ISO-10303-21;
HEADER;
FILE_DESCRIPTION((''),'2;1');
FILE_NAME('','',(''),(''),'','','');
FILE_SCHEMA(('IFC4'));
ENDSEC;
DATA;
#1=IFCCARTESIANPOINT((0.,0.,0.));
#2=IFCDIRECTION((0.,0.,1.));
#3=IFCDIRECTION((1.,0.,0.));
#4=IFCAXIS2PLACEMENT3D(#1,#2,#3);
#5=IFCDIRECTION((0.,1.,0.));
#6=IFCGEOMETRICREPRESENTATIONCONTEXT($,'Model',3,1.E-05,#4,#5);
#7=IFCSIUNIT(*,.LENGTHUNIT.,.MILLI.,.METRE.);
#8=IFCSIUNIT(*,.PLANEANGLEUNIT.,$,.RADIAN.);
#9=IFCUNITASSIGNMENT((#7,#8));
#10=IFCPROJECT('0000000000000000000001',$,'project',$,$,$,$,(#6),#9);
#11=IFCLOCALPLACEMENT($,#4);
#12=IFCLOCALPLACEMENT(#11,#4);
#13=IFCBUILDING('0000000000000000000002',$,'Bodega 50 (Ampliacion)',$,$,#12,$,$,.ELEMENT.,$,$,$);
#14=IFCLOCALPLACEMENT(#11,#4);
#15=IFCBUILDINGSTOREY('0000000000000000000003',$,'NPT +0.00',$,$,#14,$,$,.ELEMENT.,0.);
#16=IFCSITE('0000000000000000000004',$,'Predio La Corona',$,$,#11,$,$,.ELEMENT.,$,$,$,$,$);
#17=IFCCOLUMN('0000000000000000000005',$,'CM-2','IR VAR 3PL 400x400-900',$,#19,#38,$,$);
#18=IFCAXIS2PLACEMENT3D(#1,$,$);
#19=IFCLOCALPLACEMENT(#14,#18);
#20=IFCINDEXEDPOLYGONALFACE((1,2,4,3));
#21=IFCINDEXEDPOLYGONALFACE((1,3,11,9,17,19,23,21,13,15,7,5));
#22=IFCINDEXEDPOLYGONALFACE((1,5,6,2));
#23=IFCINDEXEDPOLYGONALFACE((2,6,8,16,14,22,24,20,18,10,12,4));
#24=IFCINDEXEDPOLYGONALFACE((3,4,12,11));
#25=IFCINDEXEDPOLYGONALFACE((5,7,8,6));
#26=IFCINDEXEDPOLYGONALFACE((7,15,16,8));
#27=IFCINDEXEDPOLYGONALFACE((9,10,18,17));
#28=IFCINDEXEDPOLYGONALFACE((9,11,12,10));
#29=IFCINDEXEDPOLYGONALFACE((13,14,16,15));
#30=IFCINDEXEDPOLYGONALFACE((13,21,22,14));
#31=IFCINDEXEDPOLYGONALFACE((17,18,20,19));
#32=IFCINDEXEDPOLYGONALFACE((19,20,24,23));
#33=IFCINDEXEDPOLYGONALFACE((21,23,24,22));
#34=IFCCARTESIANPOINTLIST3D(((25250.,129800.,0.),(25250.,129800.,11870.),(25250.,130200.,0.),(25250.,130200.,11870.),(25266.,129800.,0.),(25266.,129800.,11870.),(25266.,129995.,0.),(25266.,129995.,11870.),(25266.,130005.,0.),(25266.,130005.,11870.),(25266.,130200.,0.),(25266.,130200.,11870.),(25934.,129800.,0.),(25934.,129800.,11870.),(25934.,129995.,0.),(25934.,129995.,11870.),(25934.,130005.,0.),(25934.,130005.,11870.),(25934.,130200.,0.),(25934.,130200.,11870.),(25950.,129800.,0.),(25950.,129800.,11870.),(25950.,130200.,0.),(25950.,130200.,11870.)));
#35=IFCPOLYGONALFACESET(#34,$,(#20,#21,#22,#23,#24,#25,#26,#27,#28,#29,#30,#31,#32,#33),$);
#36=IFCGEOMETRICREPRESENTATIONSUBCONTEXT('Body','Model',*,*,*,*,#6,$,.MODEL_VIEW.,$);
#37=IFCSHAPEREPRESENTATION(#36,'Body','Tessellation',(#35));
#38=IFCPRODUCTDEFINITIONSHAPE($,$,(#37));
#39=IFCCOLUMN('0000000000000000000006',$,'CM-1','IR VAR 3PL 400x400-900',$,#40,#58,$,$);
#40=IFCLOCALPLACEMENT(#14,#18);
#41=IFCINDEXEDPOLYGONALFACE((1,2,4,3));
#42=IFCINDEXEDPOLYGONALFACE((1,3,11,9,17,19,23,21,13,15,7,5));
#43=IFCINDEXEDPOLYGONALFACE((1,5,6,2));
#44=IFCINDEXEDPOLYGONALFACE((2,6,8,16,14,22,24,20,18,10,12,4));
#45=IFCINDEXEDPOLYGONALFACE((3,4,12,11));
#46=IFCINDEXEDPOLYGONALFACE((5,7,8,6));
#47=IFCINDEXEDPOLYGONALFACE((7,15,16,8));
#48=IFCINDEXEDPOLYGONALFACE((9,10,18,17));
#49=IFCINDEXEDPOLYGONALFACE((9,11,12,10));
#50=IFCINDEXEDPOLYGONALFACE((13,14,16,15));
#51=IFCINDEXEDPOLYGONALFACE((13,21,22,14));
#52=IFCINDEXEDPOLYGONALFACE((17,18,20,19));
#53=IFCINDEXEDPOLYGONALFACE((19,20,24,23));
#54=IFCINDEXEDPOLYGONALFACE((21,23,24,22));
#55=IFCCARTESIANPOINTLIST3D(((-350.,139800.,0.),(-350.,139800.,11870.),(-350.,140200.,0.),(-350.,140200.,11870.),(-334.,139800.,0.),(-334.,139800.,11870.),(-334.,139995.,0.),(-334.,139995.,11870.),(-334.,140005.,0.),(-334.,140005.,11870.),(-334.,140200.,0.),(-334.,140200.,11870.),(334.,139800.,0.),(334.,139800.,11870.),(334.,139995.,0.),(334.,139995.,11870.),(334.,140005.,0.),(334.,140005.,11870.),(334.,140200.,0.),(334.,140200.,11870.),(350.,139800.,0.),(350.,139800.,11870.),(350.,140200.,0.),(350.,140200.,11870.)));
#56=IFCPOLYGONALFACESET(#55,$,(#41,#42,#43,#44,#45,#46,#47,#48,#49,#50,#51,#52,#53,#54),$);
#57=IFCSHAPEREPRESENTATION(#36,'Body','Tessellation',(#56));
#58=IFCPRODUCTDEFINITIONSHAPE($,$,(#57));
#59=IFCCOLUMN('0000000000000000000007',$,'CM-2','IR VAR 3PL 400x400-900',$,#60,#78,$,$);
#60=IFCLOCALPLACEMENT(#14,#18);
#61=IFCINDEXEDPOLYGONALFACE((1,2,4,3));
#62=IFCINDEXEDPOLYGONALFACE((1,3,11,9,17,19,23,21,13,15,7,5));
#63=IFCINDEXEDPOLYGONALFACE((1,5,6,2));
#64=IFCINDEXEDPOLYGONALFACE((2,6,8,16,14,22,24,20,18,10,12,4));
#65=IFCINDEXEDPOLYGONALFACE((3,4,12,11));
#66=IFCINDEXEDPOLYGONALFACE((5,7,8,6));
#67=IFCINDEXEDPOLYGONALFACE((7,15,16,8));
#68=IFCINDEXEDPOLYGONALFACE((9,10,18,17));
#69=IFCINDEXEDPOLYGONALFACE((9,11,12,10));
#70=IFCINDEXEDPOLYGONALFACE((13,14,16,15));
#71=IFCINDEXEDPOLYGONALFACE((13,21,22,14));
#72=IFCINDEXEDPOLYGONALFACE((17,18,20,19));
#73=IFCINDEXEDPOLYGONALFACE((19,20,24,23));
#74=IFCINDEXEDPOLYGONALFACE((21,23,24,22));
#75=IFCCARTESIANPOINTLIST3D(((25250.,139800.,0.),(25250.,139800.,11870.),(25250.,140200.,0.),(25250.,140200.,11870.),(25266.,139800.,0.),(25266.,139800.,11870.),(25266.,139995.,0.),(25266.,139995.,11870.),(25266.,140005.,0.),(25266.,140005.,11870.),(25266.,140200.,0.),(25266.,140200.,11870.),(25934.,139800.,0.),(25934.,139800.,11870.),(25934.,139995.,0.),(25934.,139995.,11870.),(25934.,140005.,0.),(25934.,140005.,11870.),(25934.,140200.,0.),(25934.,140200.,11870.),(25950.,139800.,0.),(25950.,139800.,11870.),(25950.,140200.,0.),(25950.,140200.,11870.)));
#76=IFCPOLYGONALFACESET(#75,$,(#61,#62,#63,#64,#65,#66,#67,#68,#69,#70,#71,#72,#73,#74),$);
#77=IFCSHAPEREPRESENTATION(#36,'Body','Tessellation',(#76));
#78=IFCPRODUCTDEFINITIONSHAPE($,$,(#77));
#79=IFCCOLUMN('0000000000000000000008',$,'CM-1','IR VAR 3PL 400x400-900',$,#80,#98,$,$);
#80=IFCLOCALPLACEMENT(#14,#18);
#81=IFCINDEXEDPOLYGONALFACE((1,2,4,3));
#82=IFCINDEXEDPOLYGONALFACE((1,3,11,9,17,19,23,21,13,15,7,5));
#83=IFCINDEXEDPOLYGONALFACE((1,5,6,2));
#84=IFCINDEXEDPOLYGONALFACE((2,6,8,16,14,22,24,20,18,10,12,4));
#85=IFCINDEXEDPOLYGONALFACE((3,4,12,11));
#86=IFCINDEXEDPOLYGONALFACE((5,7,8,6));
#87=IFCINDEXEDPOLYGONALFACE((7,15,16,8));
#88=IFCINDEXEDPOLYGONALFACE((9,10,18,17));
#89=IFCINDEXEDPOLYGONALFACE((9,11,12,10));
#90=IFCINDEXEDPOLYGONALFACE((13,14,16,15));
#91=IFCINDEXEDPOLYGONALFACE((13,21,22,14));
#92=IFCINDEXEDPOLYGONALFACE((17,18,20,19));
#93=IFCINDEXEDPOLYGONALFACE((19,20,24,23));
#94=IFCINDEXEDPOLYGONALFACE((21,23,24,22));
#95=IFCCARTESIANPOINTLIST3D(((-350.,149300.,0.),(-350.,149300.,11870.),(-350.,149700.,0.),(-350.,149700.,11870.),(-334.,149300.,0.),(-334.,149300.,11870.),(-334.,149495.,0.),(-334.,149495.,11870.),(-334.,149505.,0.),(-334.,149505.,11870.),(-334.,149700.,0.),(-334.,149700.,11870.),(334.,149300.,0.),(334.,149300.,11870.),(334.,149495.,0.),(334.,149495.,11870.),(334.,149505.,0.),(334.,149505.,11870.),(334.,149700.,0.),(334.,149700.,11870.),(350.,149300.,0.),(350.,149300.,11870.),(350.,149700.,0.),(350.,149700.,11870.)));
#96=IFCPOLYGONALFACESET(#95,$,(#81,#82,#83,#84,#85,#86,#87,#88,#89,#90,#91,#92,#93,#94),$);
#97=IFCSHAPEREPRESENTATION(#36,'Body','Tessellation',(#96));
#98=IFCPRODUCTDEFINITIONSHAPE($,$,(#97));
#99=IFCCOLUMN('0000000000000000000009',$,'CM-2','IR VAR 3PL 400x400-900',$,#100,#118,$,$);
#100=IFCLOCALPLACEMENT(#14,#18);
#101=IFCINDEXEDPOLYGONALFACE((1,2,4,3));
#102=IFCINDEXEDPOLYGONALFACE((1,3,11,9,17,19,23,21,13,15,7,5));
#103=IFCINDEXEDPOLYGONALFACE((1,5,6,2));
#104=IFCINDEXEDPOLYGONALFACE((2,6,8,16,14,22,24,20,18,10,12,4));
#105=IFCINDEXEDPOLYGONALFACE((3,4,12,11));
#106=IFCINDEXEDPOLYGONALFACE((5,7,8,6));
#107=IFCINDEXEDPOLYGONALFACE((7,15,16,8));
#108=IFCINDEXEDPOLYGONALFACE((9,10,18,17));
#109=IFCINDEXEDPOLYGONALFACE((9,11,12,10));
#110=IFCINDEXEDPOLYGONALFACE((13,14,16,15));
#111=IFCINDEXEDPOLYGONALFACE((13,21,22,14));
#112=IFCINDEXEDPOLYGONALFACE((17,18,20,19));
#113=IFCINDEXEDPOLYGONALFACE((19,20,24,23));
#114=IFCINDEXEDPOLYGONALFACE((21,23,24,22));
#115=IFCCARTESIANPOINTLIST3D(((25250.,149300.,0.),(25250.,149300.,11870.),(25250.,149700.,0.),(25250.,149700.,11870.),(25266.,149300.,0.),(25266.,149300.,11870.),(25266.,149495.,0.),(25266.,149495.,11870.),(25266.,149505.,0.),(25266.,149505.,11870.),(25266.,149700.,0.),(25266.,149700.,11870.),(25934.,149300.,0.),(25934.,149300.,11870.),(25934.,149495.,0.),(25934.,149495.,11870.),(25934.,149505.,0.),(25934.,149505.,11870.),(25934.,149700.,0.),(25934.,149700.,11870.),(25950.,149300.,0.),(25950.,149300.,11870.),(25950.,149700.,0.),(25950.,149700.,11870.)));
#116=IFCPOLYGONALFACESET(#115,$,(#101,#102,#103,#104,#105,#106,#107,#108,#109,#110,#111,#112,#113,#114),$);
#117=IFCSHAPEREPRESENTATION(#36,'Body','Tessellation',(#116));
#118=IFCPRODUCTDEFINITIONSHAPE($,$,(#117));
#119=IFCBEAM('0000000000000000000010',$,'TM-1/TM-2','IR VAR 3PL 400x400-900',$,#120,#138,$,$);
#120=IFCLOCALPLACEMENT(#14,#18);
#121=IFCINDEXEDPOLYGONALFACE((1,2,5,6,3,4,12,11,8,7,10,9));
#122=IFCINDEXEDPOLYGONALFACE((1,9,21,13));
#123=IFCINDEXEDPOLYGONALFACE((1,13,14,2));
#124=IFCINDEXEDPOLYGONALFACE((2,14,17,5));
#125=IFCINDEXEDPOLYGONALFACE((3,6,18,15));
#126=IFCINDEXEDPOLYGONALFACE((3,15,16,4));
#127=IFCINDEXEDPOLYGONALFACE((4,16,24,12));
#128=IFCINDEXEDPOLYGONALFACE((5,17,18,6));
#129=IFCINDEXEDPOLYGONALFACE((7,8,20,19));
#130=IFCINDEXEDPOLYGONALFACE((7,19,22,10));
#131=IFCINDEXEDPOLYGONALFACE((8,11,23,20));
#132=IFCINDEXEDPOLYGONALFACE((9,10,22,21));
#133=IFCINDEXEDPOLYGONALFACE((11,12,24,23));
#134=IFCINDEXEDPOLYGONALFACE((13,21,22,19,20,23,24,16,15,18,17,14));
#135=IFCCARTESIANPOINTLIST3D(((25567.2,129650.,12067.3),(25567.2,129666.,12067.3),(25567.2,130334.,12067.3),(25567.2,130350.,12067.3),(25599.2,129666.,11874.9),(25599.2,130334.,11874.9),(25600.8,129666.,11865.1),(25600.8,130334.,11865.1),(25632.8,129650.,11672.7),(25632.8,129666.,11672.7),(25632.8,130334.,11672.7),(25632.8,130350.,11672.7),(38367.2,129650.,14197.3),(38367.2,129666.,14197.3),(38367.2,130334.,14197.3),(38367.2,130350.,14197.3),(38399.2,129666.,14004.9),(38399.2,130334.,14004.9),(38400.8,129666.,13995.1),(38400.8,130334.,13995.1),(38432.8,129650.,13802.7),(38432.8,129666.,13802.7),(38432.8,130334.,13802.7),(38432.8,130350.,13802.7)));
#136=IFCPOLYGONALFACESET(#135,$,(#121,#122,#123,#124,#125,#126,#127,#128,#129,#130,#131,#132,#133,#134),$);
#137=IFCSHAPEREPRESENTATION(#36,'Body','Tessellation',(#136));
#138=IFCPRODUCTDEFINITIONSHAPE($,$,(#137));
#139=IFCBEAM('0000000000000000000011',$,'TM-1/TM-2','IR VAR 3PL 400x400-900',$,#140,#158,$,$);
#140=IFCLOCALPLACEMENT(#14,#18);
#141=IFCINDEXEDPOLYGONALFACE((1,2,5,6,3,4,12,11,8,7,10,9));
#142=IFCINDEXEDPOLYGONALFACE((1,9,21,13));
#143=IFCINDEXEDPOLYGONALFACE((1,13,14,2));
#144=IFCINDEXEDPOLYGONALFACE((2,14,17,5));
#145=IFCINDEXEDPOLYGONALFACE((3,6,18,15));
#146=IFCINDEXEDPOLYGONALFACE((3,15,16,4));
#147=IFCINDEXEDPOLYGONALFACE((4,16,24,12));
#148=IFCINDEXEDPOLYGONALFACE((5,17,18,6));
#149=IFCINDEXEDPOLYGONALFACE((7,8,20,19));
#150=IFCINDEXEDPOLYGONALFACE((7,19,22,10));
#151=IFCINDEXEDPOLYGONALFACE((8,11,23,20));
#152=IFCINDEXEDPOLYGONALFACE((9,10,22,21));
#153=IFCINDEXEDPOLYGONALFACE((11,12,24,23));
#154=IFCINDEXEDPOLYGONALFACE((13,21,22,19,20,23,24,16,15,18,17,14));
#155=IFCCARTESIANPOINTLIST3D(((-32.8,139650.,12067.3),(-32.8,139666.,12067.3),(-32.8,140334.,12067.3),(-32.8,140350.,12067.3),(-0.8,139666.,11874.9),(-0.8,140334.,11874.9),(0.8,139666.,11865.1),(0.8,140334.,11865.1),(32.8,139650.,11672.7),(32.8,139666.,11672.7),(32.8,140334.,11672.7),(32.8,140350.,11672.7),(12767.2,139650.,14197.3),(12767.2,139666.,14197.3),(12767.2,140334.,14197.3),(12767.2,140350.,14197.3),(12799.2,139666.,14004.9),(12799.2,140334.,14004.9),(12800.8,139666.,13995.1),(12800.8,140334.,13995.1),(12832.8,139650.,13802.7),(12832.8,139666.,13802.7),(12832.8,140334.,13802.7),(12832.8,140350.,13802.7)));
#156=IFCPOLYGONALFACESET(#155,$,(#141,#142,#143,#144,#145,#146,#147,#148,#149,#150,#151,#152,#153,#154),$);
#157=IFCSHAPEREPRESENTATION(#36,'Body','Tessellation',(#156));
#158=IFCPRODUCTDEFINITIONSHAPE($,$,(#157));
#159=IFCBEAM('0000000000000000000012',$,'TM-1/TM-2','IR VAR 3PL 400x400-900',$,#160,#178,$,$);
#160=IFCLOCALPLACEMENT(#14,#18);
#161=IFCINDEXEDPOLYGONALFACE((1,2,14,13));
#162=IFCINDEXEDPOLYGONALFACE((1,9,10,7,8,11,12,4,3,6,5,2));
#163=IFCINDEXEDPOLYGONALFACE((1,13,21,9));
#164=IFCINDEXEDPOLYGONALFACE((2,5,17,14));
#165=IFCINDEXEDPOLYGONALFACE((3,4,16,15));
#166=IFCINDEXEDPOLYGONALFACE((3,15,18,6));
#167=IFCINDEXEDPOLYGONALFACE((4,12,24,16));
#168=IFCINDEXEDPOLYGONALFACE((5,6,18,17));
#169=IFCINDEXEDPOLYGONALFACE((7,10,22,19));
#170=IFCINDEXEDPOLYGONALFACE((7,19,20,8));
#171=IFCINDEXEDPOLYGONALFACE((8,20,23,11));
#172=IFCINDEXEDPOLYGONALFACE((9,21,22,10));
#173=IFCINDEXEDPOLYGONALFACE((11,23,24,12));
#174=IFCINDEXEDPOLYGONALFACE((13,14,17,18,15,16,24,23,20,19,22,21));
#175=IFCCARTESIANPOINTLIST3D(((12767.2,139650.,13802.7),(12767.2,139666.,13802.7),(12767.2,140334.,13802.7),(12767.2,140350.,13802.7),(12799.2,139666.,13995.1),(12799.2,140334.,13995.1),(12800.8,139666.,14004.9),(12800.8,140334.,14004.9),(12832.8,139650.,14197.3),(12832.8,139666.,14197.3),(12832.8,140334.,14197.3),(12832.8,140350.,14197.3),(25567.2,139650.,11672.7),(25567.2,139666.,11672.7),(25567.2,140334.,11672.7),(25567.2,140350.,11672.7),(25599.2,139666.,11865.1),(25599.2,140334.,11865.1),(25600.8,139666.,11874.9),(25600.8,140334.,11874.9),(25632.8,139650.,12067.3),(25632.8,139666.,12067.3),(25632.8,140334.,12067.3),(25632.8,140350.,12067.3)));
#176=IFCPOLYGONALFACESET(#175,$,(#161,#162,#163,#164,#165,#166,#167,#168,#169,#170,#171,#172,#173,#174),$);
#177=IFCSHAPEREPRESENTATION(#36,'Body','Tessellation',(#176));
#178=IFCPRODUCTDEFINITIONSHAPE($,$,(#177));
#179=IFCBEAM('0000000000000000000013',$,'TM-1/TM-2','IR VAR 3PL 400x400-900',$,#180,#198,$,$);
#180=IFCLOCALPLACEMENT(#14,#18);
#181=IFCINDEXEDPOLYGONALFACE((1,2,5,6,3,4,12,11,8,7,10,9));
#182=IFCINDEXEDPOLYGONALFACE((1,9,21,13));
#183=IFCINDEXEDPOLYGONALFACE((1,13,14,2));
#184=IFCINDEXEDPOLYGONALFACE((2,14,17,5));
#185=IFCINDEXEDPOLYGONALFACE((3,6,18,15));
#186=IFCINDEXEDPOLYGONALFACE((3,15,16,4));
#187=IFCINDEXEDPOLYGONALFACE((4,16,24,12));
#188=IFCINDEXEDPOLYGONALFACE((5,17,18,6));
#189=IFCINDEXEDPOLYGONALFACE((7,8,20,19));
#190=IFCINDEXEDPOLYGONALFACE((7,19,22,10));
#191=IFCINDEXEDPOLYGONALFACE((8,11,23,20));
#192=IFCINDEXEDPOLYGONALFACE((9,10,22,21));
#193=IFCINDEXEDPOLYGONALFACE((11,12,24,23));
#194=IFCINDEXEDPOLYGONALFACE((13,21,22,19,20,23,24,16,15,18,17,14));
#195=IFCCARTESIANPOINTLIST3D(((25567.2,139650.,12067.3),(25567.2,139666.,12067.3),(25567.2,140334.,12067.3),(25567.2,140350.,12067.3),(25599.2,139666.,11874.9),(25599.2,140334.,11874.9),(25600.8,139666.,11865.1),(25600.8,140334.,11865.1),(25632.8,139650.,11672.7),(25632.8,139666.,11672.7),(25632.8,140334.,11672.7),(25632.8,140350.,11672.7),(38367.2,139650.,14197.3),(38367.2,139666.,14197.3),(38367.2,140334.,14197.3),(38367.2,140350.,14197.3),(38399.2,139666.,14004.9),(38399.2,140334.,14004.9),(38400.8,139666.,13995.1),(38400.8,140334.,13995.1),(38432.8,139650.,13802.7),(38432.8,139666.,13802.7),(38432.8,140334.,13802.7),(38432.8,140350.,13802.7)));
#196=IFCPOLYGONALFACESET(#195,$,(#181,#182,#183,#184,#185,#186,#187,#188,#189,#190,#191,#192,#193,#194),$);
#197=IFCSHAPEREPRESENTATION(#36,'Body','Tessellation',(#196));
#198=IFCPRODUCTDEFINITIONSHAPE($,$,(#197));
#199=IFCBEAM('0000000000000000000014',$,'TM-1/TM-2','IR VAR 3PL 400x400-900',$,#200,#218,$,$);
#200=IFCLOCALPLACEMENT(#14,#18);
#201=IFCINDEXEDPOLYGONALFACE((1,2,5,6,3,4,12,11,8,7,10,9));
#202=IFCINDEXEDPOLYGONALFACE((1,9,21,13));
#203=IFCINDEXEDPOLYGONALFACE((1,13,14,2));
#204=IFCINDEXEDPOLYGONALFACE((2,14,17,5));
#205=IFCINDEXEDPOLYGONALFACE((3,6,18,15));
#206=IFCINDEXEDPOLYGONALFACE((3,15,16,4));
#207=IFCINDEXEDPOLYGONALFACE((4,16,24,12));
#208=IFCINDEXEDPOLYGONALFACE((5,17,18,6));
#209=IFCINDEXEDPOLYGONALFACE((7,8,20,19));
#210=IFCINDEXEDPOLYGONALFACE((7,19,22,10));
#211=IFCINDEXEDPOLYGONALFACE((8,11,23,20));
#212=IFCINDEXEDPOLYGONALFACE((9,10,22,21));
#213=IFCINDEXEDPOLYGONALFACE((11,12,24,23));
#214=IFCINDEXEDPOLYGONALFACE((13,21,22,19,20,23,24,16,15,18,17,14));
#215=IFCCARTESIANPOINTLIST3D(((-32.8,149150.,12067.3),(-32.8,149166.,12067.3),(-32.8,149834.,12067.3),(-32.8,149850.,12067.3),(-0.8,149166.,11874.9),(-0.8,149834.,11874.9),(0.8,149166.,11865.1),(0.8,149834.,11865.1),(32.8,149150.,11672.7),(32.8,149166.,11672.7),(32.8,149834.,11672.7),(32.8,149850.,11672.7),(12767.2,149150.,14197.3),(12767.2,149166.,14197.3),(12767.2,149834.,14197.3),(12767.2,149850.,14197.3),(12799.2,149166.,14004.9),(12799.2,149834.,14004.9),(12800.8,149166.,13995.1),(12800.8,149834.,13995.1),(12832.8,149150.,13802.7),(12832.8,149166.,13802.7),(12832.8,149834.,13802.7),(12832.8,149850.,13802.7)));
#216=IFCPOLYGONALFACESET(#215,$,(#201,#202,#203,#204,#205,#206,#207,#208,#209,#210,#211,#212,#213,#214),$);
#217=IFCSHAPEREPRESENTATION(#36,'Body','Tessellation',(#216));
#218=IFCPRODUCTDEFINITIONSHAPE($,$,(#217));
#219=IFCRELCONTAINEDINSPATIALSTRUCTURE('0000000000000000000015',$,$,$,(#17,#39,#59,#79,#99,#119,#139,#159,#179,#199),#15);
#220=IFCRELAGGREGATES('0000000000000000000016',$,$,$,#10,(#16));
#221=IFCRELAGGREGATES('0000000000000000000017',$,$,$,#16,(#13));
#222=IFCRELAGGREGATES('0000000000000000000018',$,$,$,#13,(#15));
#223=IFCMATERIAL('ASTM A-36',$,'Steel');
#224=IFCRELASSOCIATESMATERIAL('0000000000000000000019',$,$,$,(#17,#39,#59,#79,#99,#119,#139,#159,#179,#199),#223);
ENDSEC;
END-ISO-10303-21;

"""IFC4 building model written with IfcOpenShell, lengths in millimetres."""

from ifc_helpers import new_model, si_unit, direction, frame, origin_with_axes, origin_2d, place, context, subcontext, project, spatial, i_section, extrude, material, element, save


model = new_model("IFC4")

# Units and contexts
model_context = context("Model", 3, precision=1e-05, world=origin_with_axes(), true_north=direction((0.0, 1.0, 0.0)))
body_context = subcontext(model_context, "Body", "Model", "MODEL_VIEW")
ifc_project = project(units=[si_unit("LENGTHUNIT", "METRE", prefix="MILLI"), si_unit("PLANEANGLEUNIT", "RADIAN")], contexts=[model_context])

# Site, building, storey
site_placement = place(None, origin_with_axes())
site = spatial("IfcSite", under=ifc_project, at=site_placement, Name="Predio La Corona", CompositionType="ELEMENT")
building_placement = place(site_placement, origin_with_axes())
building = spatial("IfcBuilding", under=site, at=building_placement, Name="Bodega 50 (Ampliacion)", CompositionType="ELEMENT")
storey_placement = place(site_placement, origin_with_axes())
storey = spatial("IfcBuildingStorey", under=building, at=storey_placement, Name="NPT +0.00", CompositionType="ELEMENT", Elevation=0.0)

# Columns
ifc_material = material(Name="ASTM A-36", Category="Steel")
for number, where, z_axis, x_axis, name in (
    (1, (25600.0, 130000.0, 0.0), (0.0, 0.0, 1.0), (0.0, -1.0, 0.0), "CM-2"),
    (2, (0.0, 140000.0, 0.0), (0.0, 0.0, 1.0), (0.0, -1.0, 0.0), "CM-1"),
    (3, (25600.0, 140000.0, 0.0), (0.0, 0.0, 1.0), (0.0, -1.0, 0.0), "CM-2"),
    (4, (0.0, 149500.0, 0.0), (0.0, 0.0, 1.0), (0.0, -1.0, 0.0), "CM-1"),
    (5, (25600.0, 149500.0, 0.0), (0.0, 0.0, 1.0), (0.0, -1.0, 0.0), "CM-2"),
):
    element("IfcColumn", number, at=place(storey_placement, frame(where, z_axis=z_axis, x_axis=x_axis)), inside=storey, material=ifc_material, Name=name, Description="IR VAR 3PL 400x400-900", context=body_context, shape_type="SweptSolid", body=[
        extrude(i_section(OverallWidth=400.0, OverallDepth=700.0, WebThickness=10.0, FlangeThickness=16.0, at=origin_2d()), origin_with_axes(), (0.0, 0.0, 1.0), 11870.0),
    ])

# Beams
for number, where, z_axis, x_axis, name in (
    (6, (25600.0, 130000.0, 11870.0), (0.986436, 0.0, 0.164149), (0.164149, 0.0, -0.986436), "TM-1/TM-2"),
    (7, (0.0, 140000.0, 11870.0), (0.986436, 0.0, 0.164149), (0.164149, 0.0, -0.986436), "TM-1/TM-2"),
    (8, (12800.0, 140000.0, 14000.0), (0.986436, 0.0, -0.164149), (-0.164149, 0.0, -0.986436), "TM-1/TM-2"),
    (9, (25600.0, 140000.0, 11870.0), (0.986436, 0.0, 0.164149), (0.164149, 0.0, -0.986436), "TM-1/TM-2"),
    (10, (0.0, 149500.0, 11870.0), (0.986436, 0.0, 0.164149), (0.164149, 0.0, -0.986436), "TM-1/TM-2"),
):
    element("IfcBeam", number, at=place(storey_placement, frame(where, z_axis=z_axis, x_axis=x_axis)), inside=storey, material=ifc_material, Name=name, Description="IR VAR 3PL 400x400-900", context=body_context, shape_type="SweptSolid", body=[
        extrude(i_section(OverallWidth=400.0, OverallDepth=700.0, WebThickness=10.0, FlangeThickness=16.0, at=origin_2d()), origin_with_axes(), (0.0, 0.0, 1.0), 12976.0),
    ])

save(model, "model.ifc")
